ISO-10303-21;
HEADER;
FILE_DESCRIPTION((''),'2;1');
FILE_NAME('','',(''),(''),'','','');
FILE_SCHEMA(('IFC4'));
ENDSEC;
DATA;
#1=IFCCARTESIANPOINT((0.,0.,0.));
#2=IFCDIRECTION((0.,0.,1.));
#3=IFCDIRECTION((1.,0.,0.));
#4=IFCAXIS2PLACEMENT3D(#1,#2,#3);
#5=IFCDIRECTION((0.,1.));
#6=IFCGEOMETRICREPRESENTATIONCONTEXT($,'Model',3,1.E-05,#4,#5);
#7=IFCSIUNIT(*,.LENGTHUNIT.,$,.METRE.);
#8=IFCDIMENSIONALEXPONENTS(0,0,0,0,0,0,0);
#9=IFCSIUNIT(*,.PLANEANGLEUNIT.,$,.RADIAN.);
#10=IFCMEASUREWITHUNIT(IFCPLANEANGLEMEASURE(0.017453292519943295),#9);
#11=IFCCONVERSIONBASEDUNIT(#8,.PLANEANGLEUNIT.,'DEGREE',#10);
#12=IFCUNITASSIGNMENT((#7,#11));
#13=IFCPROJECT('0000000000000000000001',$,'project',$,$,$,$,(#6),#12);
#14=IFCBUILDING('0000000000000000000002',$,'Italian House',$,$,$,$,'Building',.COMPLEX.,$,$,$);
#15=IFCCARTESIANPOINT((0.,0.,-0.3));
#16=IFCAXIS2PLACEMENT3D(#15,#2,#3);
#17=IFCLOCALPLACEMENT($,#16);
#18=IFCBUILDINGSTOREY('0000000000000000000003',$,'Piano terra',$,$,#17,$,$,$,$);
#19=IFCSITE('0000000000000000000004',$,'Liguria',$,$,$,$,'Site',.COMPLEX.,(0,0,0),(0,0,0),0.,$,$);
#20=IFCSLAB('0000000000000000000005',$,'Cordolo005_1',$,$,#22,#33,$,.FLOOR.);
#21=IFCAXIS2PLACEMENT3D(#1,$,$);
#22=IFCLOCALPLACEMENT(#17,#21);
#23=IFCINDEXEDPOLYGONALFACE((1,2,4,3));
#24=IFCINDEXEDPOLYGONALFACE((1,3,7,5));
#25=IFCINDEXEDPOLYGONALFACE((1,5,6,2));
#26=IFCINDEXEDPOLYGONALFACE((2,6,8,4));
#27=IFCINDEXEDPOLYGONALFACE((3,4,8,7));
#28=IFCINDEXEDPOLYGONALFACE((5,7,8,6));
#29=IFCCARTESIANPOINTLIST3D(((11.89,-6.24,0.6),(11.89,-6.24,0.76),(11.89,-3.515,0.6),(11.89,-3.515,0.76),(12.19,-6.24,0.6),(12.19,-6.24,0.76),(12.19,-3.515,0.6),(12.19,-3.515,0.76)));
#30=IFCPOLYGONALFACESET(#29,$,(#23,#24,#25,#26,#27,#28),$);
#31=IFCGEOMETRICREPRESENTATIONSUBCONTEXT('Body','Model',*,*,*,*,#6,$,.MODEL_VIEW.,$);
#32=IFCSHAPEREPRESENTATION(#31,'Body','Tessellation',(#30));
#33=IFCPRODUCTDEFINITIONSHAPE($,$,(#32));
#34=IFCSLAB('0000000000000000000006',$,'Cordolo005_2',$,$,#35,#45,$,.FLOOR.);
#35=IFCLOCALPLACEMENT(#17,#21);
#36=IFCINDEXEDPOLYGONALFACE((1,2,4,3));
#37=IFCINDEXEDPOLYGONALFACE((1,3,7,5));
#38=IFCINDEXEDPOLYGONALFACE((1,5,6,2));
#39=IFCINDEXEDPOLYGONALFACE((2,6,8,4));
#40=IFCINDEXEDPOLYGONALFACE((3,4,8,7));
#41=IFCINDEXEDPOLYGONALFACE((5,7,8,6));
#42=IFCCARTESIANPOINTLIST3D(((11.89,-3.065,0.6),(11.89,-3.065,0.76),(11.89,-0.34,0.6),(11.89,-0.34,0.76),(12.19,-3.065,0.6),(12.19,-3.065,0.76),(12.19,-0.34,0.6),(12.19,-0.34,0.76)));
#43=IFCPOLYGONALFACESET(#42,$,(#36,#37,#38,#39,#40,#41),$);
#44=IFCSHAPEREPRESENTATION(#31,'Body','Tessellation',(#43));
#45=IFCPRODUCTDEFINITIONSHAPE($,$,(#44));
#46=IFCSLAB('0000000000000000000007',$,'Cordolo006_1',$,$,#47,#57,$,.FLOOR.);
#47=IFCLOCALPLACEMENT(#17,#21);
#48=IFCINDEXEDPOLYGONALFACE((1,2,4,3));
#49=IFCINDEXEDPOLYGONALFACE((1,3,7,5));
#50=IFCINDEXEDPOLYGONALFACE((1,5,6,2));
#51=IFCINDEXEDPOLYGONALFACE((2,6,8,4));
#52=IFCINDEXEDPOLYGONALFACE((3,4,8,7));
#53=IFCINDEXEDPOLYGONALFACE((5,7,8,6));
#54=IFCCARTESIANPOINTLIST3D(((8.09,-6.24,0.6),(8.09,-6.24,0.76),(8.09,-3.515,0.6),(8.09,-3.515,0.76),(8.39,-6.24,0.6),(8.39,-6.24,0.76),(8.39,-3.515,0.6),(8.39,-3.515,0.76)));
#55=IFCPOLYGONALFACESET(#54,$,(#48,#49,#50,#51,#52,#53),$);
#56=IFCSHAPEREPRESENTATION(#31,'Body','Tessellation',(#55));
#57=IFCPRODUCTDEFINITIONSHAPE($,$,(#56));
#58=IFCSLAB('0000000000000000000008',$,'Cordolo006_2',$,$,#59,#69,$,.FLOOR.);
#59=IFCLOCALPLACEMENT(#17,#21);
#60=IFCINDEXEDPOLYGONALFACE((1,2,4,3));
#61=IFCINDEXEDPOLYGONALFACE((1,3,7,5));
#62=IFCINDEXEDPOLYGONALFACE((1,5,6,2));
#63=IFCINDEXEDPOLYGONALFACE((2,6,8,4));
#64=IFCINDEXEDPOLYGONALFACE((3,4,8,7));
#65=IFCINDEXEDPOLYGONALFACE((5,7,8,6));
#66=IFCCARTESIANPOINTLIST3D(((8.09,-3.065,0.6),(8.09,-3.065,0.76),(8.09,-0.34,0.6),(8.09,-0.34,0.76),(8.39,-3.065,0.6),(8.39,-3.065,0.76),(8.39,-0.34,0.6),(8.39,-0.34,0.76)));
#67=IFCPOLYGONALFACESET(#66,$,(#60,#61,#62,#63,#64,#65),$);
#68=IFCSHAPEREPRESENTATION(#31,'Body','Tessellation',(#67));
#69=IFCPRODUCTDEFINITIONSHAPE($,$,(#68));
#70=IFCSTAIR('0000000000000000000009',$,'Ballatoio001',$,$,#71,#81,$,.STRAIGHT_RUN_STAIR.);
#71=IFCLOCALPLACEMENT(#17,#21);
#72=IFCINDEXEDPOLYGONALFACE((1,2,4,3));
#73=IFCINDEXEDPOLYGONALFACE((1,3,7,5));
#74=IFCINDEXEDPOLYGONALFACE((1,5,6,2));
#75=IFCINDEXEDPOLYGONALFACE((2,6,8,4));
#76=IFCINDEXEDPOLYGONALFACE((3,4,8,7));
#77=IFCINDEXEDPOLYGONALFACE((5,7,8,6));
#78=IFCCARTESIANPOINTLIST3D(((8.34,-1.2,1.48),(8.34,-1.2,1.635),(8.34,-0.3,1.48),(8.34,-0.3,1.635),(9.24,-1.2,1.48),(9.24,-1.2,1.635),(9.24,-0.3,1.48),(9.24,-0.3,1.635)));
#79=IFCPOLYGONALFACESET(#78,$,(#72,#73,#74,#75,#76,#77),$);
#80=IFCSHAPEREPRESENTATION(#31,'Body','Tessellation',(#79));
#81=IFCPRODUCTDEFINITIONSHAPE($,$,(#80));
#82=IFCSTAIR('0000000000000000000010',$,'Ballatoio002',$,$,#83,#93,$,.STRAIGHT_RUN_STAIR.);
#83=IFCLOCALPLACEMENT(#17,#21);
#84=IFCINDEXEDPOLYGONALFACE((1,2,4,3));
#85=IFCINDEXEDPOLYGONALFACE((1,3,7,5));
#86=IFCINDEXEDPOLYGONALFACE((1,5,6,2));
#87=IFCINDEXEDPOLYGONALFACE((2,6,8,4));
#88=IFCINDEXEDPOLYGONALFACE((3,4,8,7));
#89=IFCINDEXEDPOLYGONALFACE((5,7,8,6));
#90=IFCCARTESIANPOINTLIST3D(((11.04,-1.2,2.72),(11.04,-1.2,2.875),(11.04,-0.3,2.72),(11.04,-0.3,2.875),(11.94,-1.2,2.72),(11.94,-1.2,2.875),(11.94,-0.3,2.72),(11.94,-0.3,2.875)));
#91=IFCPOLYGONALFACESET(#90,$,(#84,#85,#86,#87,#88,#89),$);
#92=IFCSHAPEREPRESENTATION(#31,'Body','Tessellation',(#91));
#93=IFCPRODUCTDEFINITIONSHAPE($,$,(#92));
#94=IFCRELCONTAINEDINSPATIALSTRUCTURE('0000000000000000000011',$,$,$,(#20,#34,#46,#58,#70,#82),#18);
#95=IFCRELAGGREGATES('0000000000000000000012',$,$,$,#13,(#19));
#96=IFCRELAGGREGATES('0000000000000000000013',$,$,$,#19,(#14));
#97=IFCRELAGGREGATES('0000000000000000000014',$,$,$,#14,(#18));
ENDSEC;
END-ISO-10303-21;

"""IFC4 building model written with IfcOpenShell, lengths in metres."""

from ifc_helpers import new_model, entity, si_unit, converted_unit, direction, frame, frame_2d, origin_with_axes, origin_2d_with_axis, place, context, subcontext, project, spatial, rectangle, extrude, element, save


model = new_model("IFC4")

# Units and contexts
model_context = context("Model", 3, precision=1e-05, world=origin_with_axes(), true_north=direction((0.0, 1.0)))
body_context = subcontext(model_context, "Body", "Model", "MODEL_VIEW")
ifc_project = project(units=[si_unit("LENGTHUNIT", "METRE"), converted_unit("PLANEANGLEUNIT", "DEGREE", entity("IfcPlaneAngleMeasure", 0.017453292519943295), si_unit("PLANEANGLEUNIT", "RADIAN"), dimensions=[0, 0, 0, 0, 0, 0, 0])], contexts=[model_context])

# Site, building, storey
site = spatial("IfcSite", under=ifc_project, Name="Liguria", LongName="Site", CompositionType="COMPLEX", RefLatitude=(0, 0, 0), RefLongitude=(0, 0, 0), RefElevation=0.0)
building = spatial("IfcBuilding", under=site, Name="Italian House", LongName="Building", CompositionType="COMPLEX")
storey_placement = place(None, frame((0.0, 0.0, -0.3), z_axis=(0.0, 0.0, 1.0), x_axis=(1.0, 0.0, 0.0)))
storey = spatial("IfcBuildingStorey", under=building, at=storey_placement, Name="Piano terra")

# Slabs
slab_1_placement = place(storey_placement, frame((0.0, 0.0, 0.3), z_axis=(0.0, 0.0, 1.0), x_axis=(1.0, 0.0, 0.0)))
element("IfcSlab", 1, at=slab_1_placement, inside=storey, Name="Cordolo005_1", PredefinedType="FLOOR", context=body_context, shape_type="SweptSolid", body=[
    extrude(rectangle(XDim=0.3, YDim=2.725, at=origin_2d_with_axis()), frame((12.04, -4.8775, 0.46), z_axis=(0.0, 0.0, 1.0), x_axis=(1.0, 0.0, 0.0)), (0.0, 0.0, -1.0), 0.16),
])
slab_2_placement = place(storey_placement, frame((0.0, 0.0, 0.3), z_axis=(0.0, 0.0, 1.0), x_axis=(1.0, 0.0, 0.0)))
element("IfcSlab", 2, at=slab_2_placement, inside=storey, Name="Cordolo005_2", PredefinedType="FLOOR", context=body_context, shape_type="SweptSolid", body=[
    extrude(rectangle(XDim=0.3, YDim=2.725, at=origin_2d_with_axis()), frame((12.04, -1.7025, 0.46), z_axis=(0.0, 0.0, 1.0), x_axis=(1.0, 0.0, 0.0)), (0.0, 0.0, -1.0), 0.16),
])
slab_3_placement = place(storey_placement, frame((0.0, 0.0, 0.3), z_axis=(0.0, 0.0, 1.0), x_axis=(1.0, 0.0, 0.0)))
element("IfcSlab", 3, at=slab_3_placement, inside=storey, Name="Cordolo006_1", PredefinedType="FLOOR", context=body_context, shape_type="SweptSolid", body=[
    extrude(rectangle(XDim=0.3, YDim=2.725, at=origin_2d_with_axis()), frame((8.24, -4.8775, 0.46), z_axis=(0.0, 0.0, 1.0), x_axis=(1.0, 0.0, 0.0)), (0.0, 0.0, -1.0), 0.16),
])
slab_4_placement = place(storey_placement, frame((0.0, 0.0, 0.3), z_axis=(0.0, 0.0, 1.0), x_axis=(1.0, 0.0, 0.0)))
element("IfcSlab", 4, at=slab_4_placement, inside=storey, Name="Cordolo006_2", PredefinedType="FLOOR", context=body_context, shape_type="SweptSolid", body=[
    extrude(rectangle(XDim=0.3, YDim=2.725, at=origin_2d_with_axis()), frame((8.24, -1.7025, 0.46), z_axis=(0.0, 0.0, 1.0), x_axis=(1.0, 0.0, 0.0)), (0.0, 0.0, -1.0), 0.16),
])

# Stair
stair_1_placement = place(storey_placement, frame((0.0, 0.0, 0.3), z_axis=(0.0, 0.0, 1.0), x_axis=(1.0, 0.0, 0.0)))
element("IfcStair", 5, at=stair_1_placement, inside=storey, Name="Ballatoio001", PredefinedType="STRAIGHT_RUN_STAIR", context=body_context, shape_type="SweptSolid", body=[
    extrude(rectangle(XDim=0.155, YDim=0.9, at=origin_2d_with_axis()), frame((8.34, -0.75, 1.2575), z_axis=(1.0, 0.0, 0.0), x_axis=(0.0, 0.0, -1.0)), (0.0, 0.0, 1.0), 0.9),
])

# Stair
stair_2_placement = place(storey_placement, frame((0.0, 0.0, 0.3), z_axis=(0.0, 0.0, 1.0), x_axis=(1.0, 0.0, 0.0)))
element("IfcStair", 6, at=stair_2_placement, inside=storey, Name="Ballatoio002", PredefinedType="STRAIGHT_RUN_STAIR", context=body_context, shape_type="SweptSolid", body=[
    extrude(rectangle(XDim=0.155, YDim=0.9, at=frame_2d((0.0, 0.0), x_axis=(0.0, -1.0))), frame((11.49, -0.3, 2.4975), z_axis=(0.0, -1.0, 0.0), x_axis=(1.0, 0.0, 0.0)), (0.0, 0.0, 1.0), 0.9),
])

save(model, "model.ifc")
